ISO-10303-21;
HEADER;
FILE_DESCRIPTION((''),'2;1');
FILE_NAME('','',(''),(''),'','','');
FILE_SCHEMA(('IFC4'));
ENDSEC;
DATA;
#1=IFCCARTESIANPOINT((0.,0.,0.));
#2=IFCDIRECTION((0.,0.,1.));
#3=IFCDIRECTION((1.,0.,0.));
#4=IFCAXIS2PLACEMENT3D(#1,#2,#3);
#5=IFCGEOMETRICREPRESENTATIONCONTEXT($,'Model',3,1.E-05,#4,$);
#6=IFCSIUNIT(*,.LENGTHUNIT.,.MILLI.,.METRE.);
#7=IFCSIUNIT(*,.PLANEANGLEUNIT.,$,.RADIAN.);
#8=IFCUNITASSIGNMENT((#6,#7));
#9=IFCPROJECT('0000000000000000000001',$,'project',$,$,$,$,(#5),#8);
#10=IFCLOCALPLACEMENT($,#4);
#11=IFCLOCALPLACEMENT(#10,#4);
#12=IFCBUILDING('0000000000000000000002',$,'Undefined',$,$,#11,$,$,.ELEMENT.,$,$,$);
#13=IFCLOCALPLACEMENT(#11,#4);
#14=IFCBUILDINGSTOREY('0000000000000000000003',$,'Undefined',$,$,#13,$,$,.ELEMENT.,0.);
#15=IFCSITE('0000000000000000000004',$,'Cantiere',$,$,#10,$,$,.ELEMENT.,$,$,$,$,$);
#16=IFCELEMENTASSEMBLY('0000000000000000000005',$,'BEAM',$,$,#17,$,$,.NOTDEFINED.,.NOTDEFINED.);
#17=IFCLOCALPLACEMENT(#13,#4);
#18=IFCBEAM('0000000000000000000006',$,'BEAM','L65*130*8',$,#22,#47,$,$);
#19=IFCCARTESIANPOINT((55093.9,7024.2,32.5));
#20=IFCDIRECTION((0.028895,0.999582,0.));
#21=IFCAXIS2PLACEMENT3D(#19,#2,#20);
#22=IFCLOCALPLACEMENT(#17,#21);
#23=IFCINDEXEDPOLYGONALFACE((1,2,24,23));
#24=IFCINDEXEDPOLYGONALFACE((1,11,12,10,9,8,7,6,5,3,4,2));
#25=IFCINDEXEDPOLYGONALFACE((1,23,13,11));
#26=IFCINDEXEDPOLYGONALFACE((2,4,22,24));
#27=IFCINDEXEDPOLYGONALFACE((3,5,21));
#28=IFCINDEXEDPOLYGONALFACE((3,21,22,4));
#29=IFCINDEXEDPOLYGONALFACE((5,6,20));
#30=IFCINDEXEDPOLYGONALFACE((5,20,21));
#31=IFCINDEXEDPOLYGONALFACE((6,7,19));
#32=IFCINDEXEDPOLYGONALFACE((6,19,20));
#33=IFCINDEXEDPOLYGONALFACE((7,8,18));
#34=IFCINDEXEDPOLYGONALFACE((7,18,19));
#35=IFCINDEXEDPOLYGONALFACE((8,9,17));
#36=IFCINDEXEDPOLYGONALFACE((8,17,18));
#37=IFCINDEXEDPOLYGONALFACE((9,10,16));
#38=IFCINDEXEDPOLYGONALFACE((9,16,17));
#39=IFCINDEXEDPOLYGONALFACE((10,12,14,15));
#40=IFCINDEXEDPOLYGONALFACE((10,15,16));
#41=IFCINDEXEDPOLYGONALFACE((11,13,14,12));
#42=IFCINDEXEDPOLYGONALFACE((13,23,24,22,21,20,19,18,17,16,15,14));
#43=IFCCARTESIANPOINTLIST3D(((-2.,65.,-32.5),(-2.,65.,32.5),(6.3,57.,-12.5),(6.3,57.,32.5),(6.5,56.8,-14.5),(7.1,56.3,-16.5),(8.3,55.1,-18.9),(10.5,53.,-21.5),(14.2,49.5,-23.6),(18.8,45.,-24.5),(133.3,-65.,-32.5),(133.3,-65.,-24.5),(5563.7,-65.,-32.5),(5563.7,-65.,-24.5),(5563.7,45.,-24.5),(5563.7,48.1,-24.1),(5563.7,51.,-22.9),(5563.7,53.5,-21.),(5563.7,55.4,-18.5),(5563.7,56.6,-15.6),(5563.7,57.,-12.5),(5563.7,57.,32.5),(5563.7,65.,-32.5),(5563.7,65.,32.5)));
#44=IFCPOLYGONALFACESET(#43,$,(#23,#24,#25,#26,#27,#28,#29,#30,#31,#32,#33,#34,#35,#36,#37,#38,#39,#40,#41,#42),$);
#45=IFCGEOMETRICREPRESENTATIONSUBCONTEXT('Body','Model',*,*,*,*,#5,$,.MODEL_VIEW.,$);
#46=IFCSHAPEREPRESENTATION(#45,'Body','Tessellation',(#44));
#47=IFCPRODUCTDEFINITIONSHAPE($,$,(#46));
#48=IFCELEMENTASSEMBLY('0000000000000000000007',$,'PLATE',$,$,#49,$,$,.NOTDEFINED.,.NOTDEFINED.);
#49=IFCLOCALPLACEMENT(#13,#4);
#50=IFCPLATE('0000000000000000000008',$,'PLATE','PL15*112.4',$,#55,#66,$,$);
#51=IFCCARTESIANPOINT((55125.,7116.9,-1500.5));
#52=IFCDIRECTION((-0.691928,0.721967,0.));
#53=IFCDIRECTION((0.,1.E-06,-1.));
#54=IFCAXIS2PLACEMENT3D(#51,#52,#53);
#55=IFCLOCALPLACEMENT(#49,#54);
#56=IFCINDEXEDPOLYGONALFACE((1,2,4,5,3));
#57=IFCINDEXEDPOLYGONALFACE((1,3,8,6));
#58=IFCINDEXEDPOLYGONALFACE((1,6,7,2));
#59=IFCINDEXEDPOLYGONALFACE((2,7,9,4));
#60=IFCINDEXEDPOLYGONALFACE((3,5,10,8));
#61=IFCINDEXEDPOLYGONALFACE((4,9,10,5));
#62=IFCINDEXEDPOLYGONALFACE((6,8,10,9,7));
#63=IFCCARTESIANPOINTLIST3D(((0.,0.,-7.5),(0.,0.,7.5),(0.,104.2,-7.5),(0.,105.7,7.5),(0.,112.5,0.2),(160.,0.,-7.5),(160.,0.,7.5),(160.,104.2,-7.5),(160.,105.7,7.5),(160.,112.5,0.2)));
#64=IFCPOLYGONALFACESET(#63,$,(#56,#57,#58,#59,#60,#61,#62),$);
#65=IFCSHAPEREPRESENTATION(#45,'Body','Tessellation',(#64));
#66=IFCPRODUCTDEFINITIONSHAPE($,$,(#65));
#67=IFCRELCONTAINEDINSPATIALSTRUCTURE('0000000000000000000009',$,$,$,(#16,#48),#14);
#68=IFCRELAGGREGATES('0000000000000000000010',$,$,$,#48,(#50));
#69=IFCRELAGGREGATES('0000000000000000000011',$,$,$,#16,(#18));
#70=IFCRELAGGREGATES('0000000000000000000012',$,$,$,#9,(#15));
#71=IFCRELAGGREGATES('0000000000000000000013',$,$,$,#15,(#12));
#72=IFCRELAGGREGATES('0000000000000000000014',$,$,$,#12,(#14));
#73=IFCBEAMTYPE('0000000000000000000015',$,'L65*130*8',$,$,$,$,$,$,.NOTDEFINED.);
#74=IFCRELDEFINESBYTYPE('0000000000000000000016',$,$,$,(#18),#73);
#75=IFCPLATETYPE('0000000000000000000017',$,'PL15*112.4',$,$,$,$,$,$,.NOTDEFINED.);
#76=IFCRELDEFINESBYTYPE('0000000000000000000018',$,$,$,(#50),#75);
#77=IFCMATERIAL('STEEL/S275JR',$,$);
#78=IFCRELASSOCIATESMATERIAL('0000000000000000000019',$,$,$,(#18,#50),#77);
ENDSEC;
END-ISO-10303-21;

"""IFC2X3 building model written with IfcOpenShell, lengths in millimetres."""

from ifc_helpers import new_model, si_unit, frame, origin_with_axes, origin_2d_with_axis, place, context, subcontext, project, spatial, polyline, l_section, outline, extrude, clip, halfspace, material, type_object, element, aggregate, save


model = new_model("IFC2X3")

# Units and contexts
model_context = context("Model", 3, precision=1e-05, world=origin_with_axes())
body_context = subcontext(model_context, "Body", "Model", "MODEL_VIEW")
ifc_project = project(units=[si_unit("LENGTHUNIT", "METRE", prefix="MILLI"), si_unit("PLANEANGLEUNIT", "RADIAN")], contexts=[model_context])

# Site, building, storey
site_placement = place(None, origin_with_axes())
site = spatial("IfcSite", under=ifc_project, at=site_placement, Name="Cantiere", CompositionType="ELEMENT")
building_placement = place(site_placement, origin_with_axes())
building = spatial("IfcBuilding", under=site, at=building_placement, Name="Undefined", CompositionType="ELEMENT")
storey_placement = place(building_placement, origin_with_axes())
storey = spatial("IfcBuildingStorey", under=building, at=storey_placement, Name="Undefined", CompositionType="ELEMENT", Elevation=0.0)

# Element assembly, beam
assembly_1_placement = place(storey_placement, origin_with_axes())
assembly_1 = element("IfcElementAssembly", 1, at=assembly_1_placement, inside=storey, Name="BEAM", AssemblyPlace="NOTDEFINED", PredefinedType="NOTDEFINED")
ifc_material_1 = material(Name="STEEL/S275JR")
beam_type_1 = type_object("IfcBeamType", Name="L65*130*8", PredefinedType="NOTDEFINED")
beam_1_placement = place(assembly_1_placement, frame((55093.9, 7024.2, 32.5), z_axis=(0.0, 0.0, 1.0), x_axis=(0.028895, 0.999582, 0.0)))
beam_1 = element("IfcBeam", 2, at=beam_1_placement, type_object=beam_type_1, material=ifc_material_1, Name="BEAM", Description="L65*130*8", context=body_context, shape_type="Clipping", body=[
    clip(extrude(l_section(Depth=65.0, Width=130.0, Thickness=8.0, FilletRadius=12.0, at=origin_2d_with_axis()), frame((5563.7, 0.0, 0.0), z_axis=(-1.0, 0.0, 0.0), x_axis=(0.0, -1.0, 0.0)), (0.0, 0.0, 1.0), 5570.1), halfspace(frame((133.3, -65.0, -32.5), z_axis=(0.692766, 0.721163, 0.0), x_axis=(0.0, 0.0, 1.0)), True)),
])

# Element assembly, plate
assembly_2_placement = place(storey_placement, origin_with_axes())
assembly_2 = element("IfcElementAssembly", 3, at=assembly_2_placement, inside=storey, Name="PLATE", AssemblyPlace="NOTDEFINED", PredefinedType="NOTDEFINED")
plate_type_1 = type_object("IfcPlateType", Name="PL15*112.4", PredefinedType="NOTDEFINED")
plate_1_placement = place(assembly_2_placement, frame((55125.0, 7116.9, -1500.5), z_axis=(-0.691928, 0.721967, 0.0), x_axis=(0.0, 0.000001, -1.0)))
plate_1 = element("IfcPlate", 4, at=plate_1_placement, type_object=plate_type_1, material=ifc_material_1, Name="PLATE", Description="PL15*112.4", context=body_context, shape_type="Clipping", body=[
    clip(clip(extrude(outline(polyline([(0.0, 0.0), (160.0, 0.0), (160.0, 120.0), (0.0, 120.0), (0.0, 0.0)])), frame((0.0, 0.0, -7.5), z_axis=(0.0, 0.0, 1.0), x_axis=(1.0, 0.0, 0.0)), (0.0, 0.0, 1.0), 15.0), halfspace(frame((160.0, -500.0, -572.9), z_axis=(0.0, 0.683274, -0.730162), x_axis=(0.0, 0.730162, 0.683274)), False)), halfspace(frame((160.0, 119.8, -7.5), z_axis=(0.0, 0.730162, 0.683274), x_axis=(0.0, -0.683274, 0.730162)), False)),
])
aggregate(assembly_2, [plate_1])

aggregate(assembly_1, [beam_1])

save(model, "model.ifc")
